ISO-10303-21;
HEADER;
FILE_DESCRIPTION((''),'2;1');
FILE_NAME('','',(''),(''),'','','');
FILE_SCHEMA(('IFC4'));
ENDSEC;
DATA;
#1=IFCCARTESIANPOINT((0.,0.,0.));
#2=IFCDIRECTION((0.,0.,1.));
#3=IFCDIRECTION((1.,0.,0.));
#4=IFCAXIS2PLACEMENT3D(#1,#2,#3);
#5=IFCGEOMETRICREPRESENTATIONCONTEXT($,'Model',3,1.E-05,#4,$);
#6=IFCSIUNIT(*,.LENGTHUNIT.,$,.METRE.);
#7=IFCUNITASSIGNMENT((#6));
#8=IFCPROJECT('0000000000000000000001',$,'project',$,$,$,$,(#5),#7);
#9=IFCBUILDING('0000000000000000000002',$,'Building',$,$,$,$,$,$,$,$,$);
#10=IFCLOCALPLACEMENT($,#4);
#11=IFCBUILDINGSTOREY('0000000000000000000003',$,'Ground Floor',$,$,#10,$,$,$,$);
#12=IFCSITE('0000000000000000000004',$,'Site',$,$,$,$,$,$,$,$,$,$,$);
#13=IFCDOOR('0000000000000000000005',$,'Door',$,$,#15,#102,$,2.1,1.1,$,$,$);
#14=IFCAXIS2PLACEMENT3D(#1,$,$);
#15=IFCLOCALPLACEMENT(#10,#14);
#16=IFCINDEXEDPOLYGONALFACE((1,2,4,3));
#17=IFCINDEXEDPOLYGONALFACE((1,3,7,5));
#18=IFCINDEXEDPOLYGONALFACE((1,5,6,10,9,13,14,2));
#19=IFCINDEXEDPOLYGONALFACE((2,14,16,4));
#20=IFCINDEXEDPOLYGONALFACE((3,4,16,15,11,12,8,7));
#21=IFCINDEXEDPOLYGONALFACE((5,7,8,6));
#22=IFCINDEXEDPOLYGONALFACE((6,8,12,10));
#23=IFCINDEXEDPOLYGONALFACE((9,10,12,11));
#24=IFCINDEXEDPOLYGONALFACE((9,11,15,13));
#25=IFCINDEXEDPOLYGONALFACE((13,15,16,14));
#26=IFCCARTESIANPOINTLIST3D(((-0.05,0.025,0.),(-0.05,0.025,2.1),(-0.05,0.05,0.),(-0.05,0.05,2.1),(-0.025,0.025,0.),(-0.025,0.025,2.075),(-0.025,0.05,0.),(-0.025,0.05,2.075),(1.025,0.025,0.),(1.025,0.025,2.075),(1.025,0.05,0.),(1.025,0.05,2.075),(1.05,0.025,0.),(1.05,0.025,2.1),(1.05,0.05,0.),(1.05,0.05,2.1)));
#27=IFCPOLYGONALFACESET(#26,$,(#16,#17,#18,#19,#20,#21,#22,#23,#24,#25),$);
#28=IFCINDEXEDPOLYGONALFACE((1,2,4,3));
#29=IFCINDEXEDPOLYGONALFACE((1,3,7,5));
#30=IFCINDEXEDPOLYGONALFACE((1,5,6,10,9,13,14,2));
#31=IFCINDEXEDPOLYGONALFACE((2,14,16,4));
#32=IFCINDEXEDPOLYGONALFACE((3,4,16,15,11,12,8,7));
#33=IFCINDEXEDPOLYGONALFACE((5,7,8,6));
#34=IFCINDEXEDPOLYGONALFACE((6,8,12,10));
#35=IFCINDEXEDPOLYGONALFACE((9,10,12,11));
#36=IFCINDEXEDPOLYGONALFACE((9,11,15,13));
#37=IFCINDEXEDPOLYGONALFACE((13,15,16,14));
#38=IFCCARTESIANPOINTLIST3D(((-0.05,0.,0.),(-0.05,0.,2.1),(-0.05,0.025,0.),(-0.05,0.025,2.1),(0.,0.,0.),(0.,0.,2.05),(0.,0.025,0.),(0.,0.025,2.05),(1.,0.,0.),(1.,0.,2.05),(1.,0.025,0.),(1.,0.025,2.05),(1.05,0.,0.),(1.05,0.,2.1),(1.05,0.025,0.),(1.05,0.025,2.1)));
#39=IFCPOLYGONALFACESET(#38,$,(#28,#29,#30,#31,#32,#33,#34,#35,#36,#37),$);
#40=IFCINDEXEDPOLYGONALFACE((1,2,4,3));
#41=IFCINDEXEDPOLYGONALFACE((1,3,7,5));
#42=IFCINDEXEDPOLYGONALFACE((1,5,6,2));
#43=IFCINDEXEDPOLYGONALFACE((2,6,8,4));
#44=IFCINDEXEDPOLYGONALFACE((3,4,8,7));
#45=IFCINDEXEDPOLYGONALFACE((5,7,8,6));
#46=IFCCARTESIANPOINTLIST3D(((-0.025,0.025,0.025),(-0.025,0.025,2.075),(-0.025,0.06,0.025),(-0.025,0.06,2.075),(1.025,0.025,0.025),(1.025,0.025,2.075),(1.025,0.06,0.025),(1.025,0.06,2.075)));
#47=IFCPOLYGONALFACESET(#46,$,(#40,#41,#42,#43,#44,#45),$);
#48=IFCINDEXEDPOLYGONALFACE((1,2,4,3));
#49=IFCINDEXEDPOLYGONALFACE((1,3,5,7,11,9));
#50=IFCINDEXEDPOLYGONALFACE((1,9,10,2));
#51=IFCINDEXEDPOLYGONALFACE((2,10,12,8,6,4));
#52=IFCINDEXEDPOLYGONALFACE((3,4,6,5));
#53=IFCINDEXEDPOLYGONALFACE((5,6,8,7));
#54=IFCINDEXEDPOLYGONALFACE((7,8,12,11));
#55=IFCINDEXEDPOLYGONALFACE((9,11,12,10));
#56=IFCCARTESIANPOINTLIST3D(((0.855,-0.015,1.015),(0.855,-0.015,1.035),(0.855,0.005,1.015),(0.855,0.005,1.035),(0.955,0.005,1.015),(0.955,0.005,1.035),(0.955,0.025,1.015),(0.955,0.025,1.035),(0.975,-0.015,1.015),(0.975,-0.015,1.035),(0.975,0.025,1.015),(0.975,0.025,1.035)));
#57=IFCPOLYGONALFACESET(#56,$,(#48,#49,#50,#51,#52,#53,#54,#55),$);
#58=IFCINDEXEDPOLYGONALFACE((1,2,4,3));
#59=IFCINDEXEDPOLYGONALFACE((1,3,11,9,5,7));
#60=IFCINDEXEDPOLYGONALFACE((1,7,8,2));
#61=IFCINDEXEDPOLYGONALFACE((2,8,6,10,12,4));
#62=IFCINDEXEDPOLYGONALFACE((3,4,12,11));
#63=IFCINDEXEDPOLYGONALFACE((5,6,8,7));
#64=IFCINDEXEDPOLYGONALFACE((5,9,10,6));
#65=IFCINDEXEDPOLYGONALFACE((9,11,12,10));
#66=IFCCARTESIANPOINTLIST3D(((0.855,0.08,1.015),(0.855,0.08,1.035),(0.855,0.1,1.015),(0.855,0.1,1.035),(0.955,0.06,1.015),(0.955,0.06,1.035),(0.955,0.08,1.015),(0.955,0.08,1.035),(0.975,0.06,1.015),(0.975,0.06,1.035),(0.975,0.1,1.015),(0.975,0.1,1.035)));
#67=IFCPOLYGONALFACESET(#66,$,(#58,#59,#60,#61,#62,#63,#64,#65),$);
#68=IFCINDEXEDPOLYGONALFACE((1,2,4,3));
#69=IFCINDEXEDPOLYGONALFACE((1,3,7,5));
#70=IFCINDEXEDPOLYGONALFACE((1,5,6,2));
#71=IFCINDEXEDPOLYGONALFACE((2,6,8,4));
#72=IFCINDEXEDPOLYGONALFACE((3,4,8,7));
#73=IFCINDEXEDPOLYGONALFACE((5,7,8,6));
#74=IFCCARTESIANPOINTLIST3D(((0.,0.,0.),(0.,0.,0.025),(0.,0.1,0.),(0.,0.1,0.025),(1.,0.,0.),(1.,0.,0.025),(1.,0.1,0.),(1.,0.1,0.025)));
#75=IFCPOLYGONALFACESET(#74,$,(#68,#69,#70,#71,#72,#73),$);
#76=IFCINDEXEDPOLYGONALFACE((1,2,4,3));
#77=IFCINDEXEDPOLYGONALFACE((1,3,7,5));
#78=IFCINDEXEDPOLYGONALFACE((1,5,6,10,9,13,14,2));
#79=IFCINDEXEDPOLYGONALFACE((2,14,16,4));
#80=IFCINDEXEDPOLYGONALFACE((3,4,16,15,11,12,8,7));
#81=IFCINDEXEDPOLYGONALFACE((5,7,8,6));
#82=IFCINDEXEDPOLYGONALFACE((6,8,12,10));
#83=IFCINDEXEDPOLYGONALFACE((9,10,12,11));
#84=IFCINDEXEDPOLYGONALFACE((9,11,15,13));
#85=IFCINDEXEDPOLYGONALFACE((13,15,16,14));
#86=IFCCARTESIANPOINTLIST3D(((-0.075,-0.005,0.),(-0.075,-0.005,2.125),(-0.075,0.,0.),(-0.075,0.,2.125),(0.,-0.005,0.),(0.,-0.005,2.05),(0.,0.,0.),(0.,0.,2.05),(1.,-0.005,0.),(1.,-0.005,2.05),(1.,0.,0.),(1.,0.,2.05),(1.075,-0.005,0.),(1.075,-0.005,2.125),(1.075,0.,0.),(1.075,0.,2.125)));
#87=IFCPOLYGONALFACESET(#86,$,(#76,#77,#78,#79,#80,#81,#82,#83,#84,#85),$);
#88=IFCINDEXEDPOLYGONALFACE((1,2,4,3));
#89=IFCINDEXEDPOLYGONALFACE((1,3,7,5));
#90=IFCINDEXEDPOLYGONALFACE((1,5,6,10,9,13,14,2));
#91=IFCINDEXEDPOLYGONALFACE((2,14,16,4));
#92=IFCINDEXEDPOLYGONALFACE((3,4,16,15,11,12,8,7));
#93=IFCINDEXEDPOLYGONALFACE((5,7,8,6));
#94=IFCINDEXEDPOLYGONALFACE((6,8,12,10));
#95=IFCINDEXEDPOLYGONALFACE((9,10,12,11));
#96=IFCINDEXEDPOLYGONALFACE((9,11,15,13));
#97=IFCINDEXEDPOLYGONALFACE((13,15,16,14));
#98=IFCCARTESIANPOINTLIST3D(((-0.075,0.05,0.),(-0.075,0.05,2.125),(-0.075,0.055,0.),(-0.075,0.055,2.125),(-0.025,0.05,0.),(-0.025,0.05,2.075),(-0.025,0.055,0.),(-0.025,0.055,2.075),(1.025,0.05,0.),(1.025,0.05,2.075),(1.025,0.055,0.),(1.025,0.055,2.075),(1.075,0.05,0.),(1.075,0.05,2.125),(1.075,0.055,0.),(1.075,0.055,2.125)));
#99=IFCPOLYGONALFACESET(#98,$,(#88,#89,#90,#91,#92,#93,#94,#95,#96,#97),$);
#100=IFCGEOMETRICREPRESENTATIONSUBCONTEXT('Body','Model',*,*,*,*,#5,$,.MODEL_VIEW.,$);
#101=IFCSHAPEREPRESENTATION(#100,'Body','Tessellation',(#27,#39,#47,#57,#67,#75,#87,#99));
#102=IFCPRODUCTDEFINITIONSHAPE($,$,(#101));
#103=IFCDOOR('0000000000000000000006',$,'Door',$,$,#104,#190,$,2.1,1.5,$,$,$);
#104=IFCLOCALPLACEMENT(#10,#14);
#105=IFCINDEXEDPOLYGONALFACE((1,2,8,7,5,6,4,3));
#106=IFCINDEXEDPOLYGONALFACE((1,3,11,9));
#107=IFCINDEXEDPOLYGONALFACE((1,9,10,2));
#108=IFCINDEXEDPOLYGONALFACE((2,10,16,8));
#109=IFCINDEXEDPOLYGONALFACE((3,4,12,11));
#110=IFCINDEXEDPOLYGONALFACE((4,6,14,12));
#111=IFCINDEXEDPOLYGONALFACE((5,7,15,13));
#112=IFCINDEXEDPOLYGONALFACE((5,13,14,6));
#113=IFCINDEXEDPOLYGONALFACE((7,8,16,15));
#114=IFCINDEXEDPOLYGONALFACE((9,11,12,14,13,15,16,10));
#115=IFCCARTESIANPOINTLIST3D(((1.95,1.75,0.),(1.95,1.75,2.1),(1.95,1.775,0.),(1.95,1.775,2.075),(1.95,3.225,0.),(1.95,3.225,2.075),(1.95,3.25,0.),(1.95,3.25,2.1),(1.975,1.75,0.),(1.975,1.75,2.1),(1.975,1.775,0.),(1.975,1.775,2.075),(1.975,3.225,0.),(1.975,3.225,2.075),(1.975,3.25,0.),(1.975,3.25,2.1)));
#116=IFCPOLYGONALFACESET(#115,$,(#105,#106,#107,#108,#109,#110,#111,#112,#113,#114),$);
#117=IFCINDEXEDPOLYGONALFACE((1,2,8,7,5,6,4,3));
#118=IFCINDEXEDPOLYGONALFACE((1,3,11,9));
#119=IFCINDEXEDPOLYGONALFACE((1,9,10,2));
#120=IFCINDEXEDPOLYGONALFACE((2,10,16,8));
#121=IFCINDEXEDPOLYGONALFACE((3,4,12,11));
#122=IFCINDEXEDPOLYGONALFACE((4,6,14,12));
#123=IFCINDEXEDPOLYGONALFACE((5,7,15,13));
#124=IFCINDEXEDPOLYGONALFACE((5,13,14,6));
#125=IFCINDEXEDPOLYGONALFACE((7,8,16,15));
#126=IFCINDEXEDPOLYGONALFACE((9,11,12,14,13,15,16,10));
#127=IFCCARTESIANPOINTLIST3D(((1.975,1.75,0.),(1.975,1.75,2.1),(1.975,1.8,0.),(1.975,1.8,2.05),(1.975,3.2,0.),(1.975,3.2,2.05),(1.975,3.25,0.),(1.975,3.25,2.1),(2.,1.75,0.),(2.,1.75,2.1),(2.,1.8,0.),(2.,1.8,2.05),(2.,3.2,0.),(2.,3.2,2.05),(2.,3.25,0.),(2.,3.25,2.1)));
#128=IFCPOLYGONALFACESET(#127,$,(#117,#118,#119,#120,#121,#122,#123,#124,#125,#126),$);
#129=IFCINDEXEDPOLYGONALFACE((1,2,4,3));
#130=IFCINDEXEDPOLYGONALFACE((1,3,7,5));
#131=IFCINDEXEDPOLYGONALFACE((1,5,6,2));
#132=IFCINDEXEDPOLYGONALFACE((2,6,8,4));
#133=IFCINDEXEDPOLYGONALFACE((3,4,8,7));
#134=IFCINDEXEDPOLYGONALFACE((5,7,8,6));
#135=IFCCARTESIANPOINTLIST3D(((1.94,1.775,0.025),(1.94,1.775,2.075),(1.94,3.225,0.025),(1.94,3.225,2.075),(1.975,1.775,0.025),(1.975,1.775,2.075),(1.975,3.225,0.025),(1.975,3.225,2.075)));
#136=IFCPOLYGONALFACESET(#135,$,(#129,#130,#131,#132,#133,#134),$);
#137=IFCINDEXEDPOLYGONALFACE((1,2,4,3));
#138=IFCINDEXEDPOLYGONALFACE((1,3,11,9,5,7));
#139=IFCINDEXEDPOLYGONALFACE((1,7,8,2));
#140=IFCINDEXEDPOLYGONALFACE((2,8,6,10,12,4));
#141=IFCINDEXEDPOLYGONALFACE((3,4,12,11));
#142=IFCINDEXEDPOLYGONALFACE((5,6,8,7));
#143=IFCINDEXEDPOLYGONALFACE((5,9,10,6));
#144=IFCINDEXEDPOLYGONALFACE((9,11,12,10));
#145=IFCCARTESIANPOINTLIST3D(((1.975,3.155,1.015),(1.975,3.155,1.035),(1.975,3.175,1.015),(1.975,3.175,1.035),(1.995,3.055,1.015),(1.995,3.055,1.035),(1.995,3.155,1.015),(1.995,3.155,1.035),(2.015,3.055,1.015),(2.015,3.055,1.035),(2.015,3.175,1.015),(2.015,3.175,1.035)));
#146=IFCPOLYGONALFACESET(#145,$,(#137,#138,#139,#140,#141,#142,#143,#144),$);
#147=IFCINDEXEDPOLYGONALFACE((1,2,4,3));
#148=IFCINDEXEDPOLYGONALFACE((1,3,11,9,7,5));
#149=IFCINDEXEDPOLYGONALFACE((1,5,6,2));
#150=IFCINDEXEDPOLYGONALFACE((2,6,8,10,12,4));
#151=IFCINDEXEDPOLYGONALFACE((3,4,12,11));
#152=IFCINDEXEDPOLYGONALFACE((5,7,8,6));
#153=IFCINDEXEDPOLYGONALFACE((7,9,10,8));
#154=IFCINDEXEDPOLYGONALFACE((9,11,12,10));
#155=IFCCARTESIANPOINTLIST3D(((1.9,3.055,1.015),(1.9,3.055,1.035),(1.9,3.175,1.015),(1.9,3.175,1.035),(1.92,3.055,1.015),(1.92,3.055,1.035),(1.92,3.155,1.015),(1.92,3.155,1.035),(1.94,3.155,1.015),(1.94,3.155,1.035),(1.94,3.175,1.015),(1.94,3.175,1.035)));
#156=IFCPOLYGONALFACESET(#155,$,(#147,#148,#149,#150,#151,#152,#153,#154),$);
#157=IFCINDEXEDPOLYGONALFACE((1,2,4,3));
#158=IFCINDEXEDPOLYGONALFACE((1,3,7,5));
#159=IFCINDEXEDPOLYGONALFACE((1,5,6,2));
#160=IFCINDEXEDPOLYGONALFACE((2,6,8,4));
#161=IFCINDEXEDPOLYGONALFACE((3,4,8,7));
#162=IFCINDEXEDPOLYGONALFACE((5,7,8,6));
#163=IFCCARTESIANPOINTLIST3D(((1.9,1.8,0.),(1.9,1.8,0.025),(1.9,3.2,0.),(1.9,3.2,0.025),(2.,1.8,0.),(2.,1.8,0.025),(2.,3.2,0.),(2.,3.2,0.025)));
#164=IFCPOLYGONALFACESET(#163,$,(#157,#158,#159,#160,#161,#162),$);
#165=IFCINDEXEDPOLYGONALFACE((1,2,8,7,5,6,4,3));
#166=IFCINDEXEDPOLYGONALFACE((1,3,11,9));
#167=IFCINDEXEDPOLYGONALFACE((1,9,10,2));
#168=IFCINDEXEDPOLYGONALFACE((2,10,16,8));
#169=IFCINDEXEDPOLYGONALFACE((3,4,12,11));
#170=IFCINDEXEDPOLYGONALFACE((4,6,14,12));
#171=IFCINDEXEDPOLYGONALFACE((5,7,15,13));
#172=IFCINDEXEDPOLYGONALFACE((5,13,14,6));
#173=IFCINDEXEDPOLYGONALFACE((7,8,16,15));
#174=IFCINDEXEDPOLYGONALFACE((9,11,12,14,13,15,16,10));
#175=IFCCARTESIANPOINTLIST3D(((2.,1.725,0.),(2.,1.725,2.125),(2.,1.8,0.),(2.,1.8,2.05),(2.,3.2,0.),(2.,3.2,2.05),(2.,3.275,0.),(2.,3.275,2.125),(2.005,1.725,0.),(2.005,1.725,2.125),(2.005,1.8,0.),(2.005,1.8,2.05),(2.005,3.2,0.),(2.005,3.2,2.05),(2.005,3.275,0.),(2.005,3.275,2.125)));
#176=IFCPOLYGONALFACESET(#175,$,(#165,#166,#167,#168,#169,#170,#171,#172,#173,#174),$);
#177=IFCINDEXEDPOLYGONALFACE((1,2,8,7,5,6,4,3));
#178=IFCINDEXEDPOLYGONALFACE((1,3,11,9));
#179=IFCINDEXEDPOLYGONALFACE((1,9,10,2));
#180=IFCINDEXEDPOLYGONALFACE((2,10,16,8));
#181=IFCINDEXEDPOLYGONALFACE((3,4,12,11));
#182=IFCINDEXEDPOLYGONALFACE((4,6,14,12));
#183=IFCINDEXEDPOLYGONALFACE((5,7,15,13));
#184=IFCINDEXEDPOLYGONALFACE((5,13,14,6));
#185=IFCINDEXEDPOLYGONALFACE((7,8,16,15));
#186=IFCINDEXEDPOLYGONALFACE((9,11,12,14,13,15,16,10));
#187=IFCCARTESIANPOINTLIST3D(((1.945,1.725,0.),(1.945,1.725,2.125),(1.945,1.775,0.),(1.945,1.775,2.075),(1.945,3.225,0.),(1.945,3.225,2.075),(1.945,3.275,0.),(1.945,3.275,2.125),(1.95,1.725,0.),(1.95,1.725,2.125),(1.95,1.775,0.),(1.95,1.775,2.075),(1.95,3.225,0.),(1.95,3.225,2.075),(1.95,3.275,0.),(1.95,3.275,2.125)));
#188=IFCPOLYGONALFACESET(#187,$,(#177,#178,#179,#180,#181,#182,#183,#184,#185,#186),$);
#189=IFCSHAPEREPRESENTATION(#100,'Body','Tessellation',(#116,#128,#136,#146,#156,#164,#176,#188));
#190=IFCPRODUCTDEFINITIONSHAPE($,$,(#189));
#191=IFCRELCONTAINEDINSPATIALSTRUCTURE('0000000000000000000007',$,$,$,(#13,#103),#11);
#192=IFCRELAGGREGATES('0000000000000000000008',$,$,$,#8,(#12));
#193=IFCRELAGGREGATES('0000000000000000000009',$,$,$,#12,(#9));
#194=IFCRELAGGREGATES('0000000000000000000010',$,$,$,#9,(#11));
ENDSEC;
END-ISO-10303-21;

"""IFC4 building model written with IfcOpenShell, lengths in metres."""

from ifc_helpers import new_model, si_unit, frame, origin_with_axes, place, context, subcontext, project, spatial, line, indexed_curve, outline, extrude, element, save


model = new_model("IFC4")

# Units and contexts
model_context = context("Model", 3, precision=1e-05, world=origin_with_axes())
body_context = subcontext(model_context, "Body", "Model", "MODEL_VIEW")
ifc_project = project(units=[si_unit("LENGTHUNIT", "METRE")], contexts=[model_context])

# Site, building, storey
site = spatial("IfcSite", under=ifc_project, Name="Site")
building = spatial("IfcBuilding", under=site, Name="Building")
storey_placement = place(None, origin_with_axes())
storey = spatial("IfcBuildingStorey", under=building, at=storey_placement, Name="Ground Floor")

# Doors
door_1_placement = place(storey_placement, frame((-0.05, 0.0, 0.0), z_axis=(0.0, 0.0, 1.0), x_axis=(1.0, 0.0, 0.0)))
element("IfcDoor", 1, at=door_1_placement, inside=storey, Name="Door", OverallHeight=2.1, OverallWidth=1.1, context=body_context, shape_type="SweptSolid", body=[
    extrude(outline(indexed_curve([(0.0, 0.0), (0.0, 2.1), (1.1, 2.1), (1.1, 0.0), (1.075, 0.0), (1.075, 2.075), (0.025, 2.075), (0.025, 0.0)], segments=[line(1, 2, 3, 4, 5, 6, 7, 8, 1)])), frame((0.0, 0.025, 0.0), z_axis=(0.0, -1.0, 0.0), x_axis=(1.0, 0.0, 0.0)), (0.0, 0.0, -1.0), 0.025),
    extrude(outline(indexed_curve([(0.0, 0.0), (0.0, 2.1), (1.1, 2.1), (1.1, 0.0), (1.05, 0.0), (1.05, 2.05), (0.05, 2.05), (0.05, 0.0)], segments=[line(1, 2, 3, 4, 5, 6, 7, 8, 1)])), frame((0.0, 0.0, 0.0), z_axis=(0.0, -1.0, 0.0), x_axis=(1.0, 0.0, 0.0)), (0.0, 0.0, -1.0), 0.025),
    extrude(outline(indexed_curve([(0.0, 0.0), (1.05, 0.0), (1.05, 0.035), (0.0, 0.035)], segments=[line(1, 2, 3, 4, 1)])), frame((0.025, 0.025, 0.025), z_axis=(0.0, 0.0, 1.0), x_axis=(1.0, 0.0, 0.0)), (0.0, 0.0, 1.0), 2.05),
    extrude(outline(indexed_curve([(0.0, 0.0), (0.0, -0.04), (-0.12, -0.04), (-0.12, -0.02), (-0.02, -0.02), (-0.02, 0.0)], segments=[line(1, 2, 3, 4, 5, 6, 1)])), frame((1.025, 0.025, 1.015), z_axis=(0.0, 0.0, 1.0), x_axis=(1.0, 0.0, 0.0)), (0.0, 0.0, 1.0), 0.02),
    extrude(outline(indexed_curve([(0.0, 0.0), (0.0, 0.04), (-0.12, 0.04), (-0.12, 0.02), (-0.02, 0.02), (-0.02, 0.0)], segments=[line(1, 2, 3, 4, 5, 6, 1)])), frame((1.025, 0.06, 1.015), z_axis=(0.0, 0.0, 1.0), x_axis=(1.0, 0.0, 0.0)), (0.0, 0.0, 1.0), 0.02),
    extrude(outline(indexed_curve([(0.0, 0.0), (1.0, 0.0), (1.0, 0.1), (0.0, 0.1)], segments=[line(1, 2, 3, 4, 1)])), frame((0.05, 0.0, 0.0), z_axis=(0.0, 0.0, 1.0), x_axis=(1.0, 0.0, 0.0)), (0.0, 0.0, 1.0), 0.025),
    extrude(outline(indexed_curve([(0.0, 0.0), (0.0, 2.125), (1.15, 2.125), (1.15, 0.0), (1.075, 0.0), (1.075, 2.05), (0.075, 2.05), (0.075, 0.0)], segments=[line(1, 2, 3, 4, 5, 6, 7, 8, 1)])), frame((-0.025, -0.005, 0.0), z_axis=(0.0, -1.0, 0.0), x_axis=(1.0, 0.0, 0.0)), (0.0, 0.0, -1.0), 0.005),
    extrude(outline(indexed_curve([(0.0, 0.0), (0.0, 2.125), (1.15, 2.125), (1.15, 0.0), (1.1, 0.0), (1.1, 2.075), (0.05, 2.075), (0.05, 0.0)], segments=[line(1, 2, 3, 4, 5, 6, 7, 8, 1)])), frame((-0.025, 0.05, 0.0), z_axis=(0.0, -1.0, 0.0), x_axis=(1.0, 0.0, 0.0)), (0.0, 0.0, -1.0), 0.005),
])
door_2_placement = place(storey_placement, frame((2.0, 1.75, 0.0), z_axis=(0.0, 0.0, 1.0), x_axis=(0.0, 1.0, 0.0)))
element("IfcDoor", 2, at=door_2_placement, inside=storey, Name="Door", OverallHeight=2.1, OverallWidth=1.5, context=body_context, shape_type="SweptSolid", body=[
    extrude(outline(indexed_curve([(0.0, 0.0), (0.0, 2.1), (1.5, 2.1), (1.5, 0.0), (1.475, 0.0), (1.475, 2.075), (0.025, 2.075), (0.025, 0.0)], segments=[line(1, 2, 3, 4, 5, 6, 7, 8, 1)])), frame((0.0, 0.025, 0.0), z_axis=(0.0, -1.0, 0.0), x_axis=(1.0, 0.0, 0.0)), (0.0, 0.0, -1.0), 0.025),
    extrude(outline(indexed_curve([(0.0, 0.0), (0.0, 2.1), (1.5, 2.1), (1.5, 0.0), (1.45, 0.0), (1.45, 2.05), (0.05, 2.05), (0.05, 0.0)], segments=[line(1, 2, 3, 4, 5, 6, 7, 8, 1)])), frame((0.0, 0.0, 0.0), z_axis=(0.0, -1.0, 0.0), x_axis=(1.0, 0.0, 0.0)), (0.0, 0.0, -1.0), 0.025),
    extrude(outline(indexed_curve([(0.0, 0.0), (1.45, 0.0), (1.45, 0.035), (0.0, 0.035)], segments=[line(1, 2, 3, 4, 1)])), frame((0.025, 0.025, 0.025), z_axis=(0.0, 0.0, 1.0), x_axis=(1.0, 0.0, 0.0)), (0.0, 0.0, 1.0), 2.05),
    extrude(outline(indexed_curve([(0.0, 0.0), (0.0, -0.04), (-0.12, -0.04), (-0.12, -0.02), (-0.02, -0.02), (-0.02, 0.0)], segments=[line(1, 2, 3, 4, 5, 6, 1)])), frame((1.425, 0.025, 1.015), z_axis=(0.0, 0.0, 1.0), x_axis=(1.0, 0.0, 0.0)), (0.0, 0.0, 1.0), 0.02),
    extrude(outline(indexed_curve([(0.0, 0.0), (0.0, 0.04), (-0.12, 0.04), (-0.12, 0.02), (-0.02, 0.02), (-0.02, 0.0)], segments=[line(1, 2, 3, 4, 5, 6, 1)])), frame((1.425, 0.06, 1.015), z_axis=(0.0, 0.0, 1.0), x_axis=(1.0, 0.0, 0.0)), (0.0, 0.0, 1.0), 0.02),
    extrude(outline(indexed_curve([(0.0, 0.0), (1.4, 0.0), (1.4, 0.1), (0.0, 0.1)], segments=[line(1, 2, 3, 4, 1)])), frame((0.05, 0.0, 0.0), z_axis=(0.0, 0.0, 1.0), x_axis=(1.0, 0.0, 0.0)), (0.0, 0.0, 1.0), 0.025),
    extrude(outline(indexed_curve([(0.0, 0.0), (0.0, 2.125), (1.55, 2.125), (1.55, 0.0), (1.475, 0.0), (1.475, 2.05), (0.075, 2.05), (0.075, 0.0)], segments=[line(1, 2, 3, 4, 5, 6, 7, 8, 1)])), frame((-0.025, -0.005, 0.0), z_axis=(0.0, -1.0, 0.0), x_axis=(1.0, 0.0, 0.0)), (0.0, 0.0, -1.0), 0.005),
    extrude(outline(indexed_curve([(0.0, 0.0), (0.0, 2.125), (1.55, 2.125), (1.55, 0.0), (1.5, 0.0), (1.5, 2.075), (0.05, 2.075), (0.05, 0.0)], segments=[line(1, 2, 3, 4, 5, 6, 7, 8, 1)])), frame((-0.025, 0.05, 0.0), z_axis=(0.0, -1.0, 0.0), x_axis=(1.0, 0.0, 0.0)), (0.0, 0.0, -1.0), 0.005),
])

save(model, "model.ifc")
